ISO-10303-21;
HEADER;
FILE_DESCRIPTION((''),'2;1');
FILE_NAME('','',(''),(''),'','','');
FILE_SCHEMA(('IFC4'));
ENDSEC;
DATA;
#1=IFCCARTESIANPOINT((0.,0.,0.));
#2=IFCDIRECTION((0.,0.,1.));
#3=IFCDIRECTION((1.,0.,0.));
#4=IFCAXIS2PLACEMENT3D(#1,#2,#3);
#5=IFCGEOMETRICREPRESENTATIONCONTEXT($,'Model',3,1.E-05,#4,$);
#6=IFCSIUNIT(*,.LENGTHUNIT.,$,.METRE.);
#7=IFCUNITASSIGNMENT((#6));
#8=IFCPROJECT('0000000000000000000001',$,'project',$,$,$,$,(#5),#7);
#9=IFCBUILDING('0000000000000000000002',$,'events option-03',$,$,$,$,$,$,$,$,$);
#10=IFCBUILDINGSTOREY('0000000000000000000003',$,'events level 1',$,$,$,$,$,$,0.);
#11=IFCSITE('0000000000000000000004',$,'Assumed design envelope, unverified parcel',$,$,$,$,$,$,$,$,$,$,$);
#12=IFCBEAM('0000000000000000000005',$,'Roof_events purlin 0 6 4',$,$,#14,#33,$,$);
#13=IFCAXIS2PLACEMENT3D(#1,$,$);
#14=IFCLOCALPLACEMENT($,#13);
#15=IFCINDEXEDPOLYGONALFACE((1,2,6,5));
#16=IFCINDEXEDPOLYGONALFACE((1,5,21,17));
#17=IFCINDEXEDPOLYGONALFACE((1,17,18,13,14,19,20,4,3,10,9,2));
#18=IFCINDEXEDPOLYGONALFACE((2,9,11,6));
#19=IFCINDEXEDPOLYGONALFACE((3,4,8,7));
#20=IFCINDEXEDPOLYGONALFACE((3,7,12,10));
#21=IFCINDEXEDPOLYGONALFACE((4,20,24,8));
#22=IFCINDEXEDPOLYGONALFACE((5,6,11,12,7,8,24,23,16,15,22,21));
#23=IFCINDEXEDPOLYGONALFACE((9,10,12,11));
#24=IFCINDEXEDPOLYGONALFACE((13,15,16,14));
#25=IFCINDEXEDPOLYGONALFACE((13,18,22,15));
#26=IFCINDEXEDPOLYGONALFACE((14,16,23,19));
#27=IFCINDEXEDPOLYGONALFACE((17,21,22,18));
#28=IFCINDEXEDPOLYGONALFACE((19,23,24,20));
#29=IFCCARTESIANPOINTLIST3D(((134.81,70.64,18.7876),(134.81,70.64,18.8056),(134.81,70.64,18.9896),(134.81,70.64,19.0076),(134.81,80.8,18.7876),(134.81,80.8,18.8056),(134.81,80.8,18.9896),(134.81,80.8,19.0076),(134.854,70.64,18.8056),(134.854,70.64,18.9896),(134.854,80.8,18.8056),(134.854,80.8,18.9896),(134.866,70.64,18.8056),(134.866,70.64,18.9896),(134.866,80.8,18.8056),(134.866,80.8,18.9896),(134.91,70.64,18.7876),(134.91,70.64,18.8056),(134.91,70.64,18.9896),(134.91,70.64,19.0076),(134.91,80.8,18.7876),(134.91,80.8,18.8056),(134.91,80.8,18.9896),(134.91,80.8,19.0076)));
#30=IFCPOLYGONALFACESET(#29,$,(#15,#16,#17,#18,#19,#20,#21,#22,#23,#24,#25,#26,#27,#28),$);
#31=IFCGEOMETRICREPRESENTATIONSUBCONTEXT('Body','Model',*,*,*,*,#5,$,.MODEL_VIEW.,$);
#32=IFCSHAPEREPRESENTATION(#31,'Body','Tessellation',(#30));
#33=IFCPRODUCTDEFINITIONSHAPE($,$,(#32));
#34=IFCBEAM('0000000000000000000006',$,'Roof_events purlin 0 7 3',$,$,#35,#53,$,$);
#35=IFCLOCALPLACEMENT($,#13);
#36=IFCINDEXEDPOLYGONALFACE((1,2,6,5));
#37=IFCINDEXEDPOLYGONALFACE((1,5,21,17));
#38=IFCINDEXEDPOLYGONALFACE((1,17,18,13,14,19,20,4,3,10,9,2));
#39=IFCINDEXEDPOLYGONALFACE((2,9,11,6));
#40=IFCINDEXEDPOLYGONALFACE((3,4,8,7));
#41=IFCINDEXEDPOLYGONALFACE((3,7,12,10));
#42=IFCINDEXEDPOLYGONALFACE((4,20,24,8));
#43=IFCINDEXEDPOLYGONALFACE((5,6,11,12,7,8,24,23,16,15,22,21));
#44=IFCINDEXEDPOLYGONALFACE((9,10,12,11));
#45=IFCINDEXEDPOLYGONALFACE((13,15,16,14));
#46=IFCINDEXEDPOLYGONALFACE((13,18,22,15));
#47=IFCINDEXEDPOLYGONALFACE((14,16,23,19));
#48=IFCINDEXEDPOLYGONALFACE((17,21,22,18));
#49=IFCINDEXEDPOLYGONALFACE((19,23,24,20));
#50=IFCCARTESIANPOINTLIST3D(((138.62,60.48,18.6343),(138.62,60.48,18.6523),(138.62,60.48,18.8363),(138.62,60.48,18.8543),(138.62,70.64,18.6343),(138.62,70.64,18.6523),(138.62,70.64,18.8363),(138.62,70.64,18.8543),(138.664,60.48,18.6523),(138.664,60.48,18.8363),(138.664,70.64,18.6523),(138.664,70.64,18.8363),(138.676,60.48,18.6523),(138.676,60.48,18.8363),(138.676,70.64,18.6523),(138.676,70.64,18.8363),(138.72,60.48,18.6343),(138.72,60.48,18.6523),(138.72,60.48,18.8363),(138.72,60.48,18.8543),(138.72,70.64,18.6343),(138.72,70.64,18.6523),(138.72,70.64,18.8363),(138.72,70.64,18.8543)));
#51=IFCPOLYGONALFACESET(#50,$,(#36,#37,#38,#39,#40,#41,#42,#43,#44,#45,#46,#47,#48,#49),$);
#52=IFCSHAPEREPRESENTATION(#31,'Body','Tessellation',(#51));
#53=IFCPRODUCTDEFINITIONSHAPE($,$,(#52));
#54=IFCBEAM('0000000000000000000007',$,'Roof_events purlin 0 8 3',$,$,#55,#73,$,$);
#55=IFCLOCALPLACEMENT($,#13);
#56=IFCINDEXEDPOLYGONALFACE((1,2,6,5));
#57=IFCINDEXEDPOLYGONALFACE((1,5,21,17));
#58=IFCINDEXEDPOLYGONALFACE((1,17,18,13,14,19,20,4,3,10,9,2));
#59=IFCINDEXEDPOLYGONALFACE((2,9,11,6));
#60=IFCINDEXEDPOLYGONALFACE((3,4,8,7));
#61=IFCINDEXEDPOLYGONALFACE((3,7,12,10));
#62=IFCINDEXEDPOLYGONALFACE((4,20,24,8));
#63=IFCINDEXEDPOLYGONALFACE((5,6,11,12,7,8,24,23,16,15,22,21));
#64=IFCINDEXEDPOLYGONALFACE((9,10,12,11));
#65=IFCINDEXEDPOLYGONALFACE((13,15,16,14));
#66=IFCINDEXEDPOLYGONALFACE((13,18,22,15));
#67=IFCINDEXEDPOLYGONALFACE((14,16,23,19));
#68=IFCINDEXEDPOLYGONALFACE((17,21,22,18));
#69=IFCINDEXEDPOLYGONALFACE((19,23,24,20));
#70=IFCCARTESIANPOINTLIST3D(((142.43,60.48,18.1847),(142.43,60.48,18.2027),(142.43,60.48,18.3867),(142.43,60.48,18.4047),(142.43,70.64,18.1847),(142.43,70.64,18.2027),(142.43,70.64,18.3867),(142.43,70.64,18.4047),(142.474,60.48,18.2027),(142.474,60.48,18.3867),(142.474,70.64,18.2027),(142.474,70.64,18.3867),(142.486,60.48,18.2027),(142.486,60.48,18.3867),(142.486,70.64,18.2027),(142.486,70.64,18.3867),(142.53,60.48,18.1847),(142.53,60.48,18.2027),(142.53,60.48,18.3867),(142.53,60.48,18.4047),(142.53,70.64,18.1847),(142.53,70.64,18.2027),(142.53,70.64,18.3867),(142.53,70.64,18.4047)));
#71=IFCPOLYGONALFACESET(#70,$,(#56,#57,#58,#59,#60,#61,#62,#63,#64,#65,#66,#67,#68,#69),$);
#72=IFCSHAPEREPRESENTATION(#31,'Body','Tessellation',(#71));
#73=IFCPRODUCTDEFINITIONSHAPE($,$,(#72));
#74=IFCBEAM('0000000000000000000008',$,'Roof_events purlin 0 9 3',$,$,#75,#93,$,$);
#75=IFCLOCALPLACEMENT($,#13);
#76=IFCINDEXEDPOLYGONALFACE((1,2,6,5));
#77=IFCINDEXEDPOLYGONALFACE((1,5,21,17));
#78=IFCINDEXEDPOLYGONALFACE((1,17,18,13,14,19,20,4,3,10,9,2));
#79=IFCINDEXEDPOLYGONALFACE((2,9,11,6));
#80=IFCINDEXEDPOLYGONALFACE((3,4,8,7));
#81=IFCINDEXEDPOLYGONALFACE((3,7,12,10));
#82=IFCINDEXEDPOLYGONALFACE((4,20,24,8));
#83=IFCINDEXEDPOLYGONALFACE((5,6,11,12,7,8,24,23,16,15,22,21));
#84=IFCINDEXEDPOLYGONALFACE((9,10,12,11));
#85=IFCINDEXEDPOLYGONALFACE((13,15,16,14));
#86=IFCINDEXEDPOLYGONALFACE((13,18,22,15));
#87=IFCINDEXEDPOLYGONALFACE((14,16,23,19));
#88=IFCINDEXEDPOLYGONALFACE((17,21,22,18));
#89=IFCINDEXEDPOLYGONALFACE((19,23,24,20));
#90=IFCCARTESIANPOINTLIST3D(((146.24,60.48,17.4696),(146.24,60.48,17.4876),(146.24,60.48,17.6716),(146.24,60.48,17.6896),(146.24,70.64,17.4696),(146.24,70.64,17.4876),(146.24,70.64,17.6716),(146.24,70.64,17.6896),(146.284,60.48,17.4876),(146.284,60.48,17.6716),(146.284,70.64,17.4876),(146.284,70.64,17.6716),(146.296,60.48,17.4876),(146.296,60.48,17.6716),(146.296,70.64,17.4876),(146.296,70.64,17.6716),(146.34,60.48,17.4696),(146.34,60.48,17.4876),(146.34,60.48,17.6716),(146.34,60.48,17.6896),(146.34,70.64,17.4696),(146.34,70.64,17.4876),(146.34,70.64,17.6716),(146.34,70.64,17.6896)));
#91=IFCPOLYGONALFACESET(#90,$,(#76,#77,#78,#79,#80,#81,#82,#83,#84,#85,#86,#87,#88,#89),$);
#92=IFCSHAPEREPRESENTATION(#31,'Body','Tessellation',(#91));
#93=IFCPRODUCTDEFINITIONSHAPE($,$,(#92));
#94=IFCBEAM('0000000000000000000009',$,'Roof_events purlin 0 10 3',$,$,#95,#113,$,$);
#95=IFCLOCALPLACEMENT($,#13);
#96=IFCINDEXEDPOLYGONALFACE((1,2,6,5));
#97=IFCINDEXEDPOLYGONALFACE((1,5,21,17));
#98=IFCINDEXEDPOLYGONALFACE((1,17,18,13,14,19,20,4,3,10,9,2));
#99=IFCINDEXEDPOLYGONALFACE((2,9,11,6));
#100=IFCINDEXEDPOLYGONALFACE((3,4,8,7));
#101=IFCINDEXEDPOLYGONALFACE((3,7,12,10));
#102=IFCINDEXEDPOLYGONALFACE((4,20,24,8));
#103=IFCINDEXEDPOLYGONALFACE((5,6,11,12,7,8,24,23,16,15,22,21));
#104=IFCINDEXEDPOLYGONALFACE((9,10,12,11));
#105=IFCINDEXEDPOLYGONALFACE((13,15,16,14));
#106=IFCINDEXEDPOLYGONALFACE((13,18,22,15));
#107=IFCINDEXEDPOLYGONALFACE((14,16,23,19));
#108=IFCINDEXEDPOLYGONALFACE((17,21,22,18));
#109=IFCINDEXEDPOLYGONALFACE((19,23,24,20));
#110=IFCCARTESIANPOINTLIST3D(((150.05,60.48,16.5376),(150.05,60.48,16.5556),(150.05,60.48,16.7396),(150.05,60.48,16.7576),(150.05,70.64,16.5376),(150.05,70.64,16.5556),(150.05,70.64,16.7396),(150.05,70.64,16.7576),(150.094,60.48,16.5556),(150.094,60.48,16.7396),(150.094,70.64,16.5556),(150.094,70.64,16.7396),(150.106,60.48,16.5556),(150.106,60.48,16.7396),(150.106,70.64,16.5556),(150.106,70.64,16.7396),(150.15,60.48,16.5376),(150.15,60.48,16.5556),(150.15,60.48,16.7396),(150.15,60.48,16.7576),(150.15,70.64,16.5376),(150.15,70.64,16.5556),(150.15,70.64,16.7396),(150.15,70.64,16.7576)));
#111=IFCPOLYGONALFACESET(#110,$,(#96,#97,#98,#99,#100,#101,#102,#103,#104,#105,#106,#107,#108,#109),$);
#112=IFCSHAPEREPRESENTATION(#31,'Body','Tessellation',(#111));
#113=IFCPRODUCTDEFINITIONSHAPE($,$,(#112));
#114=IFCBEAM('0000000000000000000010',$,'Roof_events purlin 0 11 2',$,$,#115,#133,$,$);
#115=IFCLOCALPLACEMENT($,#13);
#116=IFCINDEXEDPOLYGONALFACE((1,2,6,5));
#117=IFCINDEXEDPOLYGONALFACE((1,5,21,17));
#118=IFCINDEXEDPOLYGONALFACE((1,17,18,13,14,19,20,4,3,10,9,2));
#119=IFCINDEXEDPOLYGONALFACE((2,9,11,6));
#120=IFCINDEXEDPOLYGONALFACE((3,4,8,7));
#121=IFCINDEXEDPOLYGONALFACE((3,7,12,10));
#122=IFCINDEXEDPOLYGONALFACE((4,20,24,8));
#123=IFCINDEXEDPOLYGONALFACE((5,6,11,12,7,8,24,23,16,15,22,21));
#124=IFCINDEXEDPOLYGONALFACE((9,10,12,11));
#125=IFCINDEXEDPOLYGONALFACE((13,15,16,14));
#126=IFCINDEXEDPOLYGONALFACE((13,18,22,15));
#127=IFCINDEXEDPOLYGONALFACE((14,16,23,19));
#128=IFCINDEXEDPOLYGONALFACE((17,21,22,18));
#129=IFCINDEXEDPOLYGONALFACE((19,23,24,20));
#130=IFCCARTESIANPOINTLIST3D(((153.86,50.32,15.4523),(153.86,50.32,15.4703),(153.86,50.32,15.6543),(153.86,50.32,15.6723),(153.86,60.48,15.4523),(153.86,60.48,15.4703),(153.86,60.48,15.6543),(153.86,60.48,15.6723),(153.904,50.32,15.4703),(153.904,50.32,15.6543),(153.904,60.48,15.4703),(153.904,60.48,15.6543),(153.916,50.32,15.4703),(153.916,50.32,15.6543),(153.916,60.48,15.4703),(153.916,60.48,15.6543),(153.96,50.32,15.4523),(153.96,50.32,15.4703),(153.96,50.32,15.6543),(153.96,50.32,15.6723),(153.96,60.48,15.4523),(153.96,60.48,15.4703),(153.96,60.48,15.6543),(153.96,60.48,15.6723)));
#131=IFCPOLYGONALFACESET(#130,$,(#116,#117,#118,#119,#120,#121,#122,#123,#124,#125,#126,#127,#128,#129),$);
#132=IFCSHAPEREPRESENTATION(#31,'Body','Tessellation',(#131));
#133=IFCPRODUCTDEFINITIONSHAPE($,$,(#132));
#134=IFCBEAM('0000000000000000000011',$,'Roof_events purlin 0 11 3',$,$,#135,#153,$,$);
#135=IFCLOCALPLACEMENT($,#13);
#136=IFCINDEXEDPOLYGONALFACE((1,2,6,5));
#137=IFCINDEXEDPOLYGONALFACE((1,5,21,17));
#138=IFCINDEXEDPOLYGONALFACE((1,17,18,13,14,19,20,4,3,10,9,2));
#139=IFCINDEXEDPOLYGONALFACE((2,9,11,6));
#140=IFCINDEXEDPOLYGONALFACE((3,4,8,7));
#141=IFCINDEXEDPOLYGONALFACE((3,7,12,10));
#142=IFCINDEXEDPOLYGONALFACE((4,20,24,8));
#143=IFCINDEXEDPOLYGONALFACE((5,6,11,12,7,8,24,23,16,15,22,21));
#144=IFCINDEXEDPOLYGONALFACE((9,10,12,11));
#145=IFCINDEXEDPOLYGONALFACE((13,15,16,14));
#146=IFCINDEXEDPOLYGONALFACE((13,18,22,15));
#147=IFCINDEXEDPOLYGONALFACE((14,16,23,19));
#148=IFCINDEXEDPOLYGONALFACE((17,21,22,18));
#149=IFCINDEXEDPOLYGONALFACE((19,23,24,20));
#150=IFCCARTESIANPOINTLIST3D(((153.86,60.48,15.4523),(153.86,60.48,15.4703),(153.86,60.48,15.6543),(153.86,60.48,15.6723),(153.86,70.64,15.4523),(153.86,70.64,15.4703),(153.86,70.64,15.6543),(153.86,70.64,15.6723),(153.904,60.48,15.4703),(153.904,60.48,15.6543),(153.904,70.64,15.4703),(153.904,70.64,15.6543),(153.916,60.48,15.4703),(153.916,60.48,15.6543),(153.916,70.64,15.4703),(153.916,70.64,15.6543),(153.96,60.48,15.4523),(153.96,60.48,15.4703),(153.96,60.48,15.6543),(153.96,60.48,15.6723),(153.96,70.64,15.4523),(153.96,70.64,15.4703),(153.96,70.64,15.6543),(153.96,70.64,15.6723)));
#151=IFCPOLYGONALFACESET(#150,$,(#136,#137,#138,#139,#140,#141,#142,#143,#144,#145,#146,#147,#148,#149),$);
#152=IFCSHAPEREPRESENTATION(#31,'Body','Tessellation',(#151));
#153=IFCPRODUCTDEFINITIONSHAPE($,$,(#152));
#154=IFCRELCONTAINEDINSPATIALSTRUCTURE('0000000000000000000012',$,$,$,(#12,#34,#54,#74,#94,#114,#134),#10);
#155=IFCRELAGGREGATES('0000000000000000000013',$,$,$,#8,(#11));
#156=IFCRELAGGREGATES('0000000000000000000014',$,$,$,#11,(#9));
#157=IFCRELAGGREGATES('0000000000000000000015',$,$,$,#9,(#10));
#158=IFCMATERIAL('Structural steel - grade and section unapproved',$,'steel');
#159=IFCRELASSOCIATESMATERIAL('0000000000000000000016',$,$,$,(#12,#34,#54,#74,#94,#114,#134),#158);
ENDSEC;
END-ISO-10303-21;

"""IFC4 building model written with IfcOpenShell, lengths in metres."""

from ifc_helpers import new_model, si_unit, frame, origin_with_axes, place, context, subcontext, project, spatial, i_section, extrude, material, element, save


model = new_model("IFC4")

# Units and contexts
model_context = context("Model", 3, precision=1e-05, world=origin_with_axes())
body_context = subcontext(model_context, "Body", "Model", "MODEL_VIEW")
ifc_project = project(units=[si_unit("LENGTHUNIT", "METRE")], contexts=[model_context])

# Site, building, storey
site = spatial("IfcSite", under=ifc_project, Name="Assumed design envelope, unverified parcel")
building = spatial("IfcBuilding", under=site, Name="events option-03")
storey = spatial("IfcBuildingStorey", under=building, Name="events level 1", Elevation=0.0)

# Beams
ifc_material = material(Name="Structural steel - grade and section unapproved", Category="steel")
beam_1_placement = place(None, frame((134.86, 70.64, 18.8976), z_axis=(0.0, 1.0, 0.0), x_axis=(-1.0, 0.0, 0.0)))
element("IfcBeam", 1, at=beam_1_placement, inside=storey, material=ifc_material, Name="Roof_events purlin 0 6 4", context=body_context, shape_type="SweptSolid", body=[
    extrude(i_section(OverallWidth=0.1, OverallDepth=0.22, WebThickness=0.012, FlangeThickness=0.018, FilletRadius=0.0), origin_with_axes(), (0.0, 0.0, 1.0), 10.16),
])
for number, where, z_axis, x_axis, name in (
    (2, (138.67, 60.48, 18.7443), (0.0, 1.0, 0.0), (-1.0, 0.0, 0.0), "Roof_events purlin 0 7 3"),
    (3, (142.48, 60.48, 18.2947), (0.0, 1.0, 0.0), (-1.0, 0.0, 0.0), "Roof_events purlin 0 8 3"),
    (4, (146.29, 60.48, 17.5796), (0.0, 1.0, 0.0), (-1.0, 0.0, 0.0), "Roof_events purlin 0 9 3"),
    (5, (150.1, 60.48, 16.6476), (0.0, 1.0, 0.0), (-1.0, 0.0, 0.0), "Roof_events purlin 0 10 3"),
    (6, (153.91, 50.32, 15.5623), (0.0, 1.0, 0.0), (-1.0, 0.0, 0.0), "Roof_events purlin 0 11 2"),
    (7, (153.91, 60.48, 15.5623), (0.0, 1.0, 0.0), (-1.0, 0.0, 0.0), "Roof_events purlin 0 11 3"),
):
    element("IfcBeam", number, at=place(None, frame(where, z_axis=z_axis, x_axis=x_axis)), inside=storey, material=ifc_material, Name=name, context=body_context, shape_type="SweptSolid", body=[
        extrude(i_section(OverallWidth=0.1, OverallDepth=0.22, WebThickness=0.012, FlangeThickness=0.018, FilletRadius=0.0), origin_with_axes(), (0.0, 0.0, 1.0), 10.16),
    ])

save(model, "model.ifc")
